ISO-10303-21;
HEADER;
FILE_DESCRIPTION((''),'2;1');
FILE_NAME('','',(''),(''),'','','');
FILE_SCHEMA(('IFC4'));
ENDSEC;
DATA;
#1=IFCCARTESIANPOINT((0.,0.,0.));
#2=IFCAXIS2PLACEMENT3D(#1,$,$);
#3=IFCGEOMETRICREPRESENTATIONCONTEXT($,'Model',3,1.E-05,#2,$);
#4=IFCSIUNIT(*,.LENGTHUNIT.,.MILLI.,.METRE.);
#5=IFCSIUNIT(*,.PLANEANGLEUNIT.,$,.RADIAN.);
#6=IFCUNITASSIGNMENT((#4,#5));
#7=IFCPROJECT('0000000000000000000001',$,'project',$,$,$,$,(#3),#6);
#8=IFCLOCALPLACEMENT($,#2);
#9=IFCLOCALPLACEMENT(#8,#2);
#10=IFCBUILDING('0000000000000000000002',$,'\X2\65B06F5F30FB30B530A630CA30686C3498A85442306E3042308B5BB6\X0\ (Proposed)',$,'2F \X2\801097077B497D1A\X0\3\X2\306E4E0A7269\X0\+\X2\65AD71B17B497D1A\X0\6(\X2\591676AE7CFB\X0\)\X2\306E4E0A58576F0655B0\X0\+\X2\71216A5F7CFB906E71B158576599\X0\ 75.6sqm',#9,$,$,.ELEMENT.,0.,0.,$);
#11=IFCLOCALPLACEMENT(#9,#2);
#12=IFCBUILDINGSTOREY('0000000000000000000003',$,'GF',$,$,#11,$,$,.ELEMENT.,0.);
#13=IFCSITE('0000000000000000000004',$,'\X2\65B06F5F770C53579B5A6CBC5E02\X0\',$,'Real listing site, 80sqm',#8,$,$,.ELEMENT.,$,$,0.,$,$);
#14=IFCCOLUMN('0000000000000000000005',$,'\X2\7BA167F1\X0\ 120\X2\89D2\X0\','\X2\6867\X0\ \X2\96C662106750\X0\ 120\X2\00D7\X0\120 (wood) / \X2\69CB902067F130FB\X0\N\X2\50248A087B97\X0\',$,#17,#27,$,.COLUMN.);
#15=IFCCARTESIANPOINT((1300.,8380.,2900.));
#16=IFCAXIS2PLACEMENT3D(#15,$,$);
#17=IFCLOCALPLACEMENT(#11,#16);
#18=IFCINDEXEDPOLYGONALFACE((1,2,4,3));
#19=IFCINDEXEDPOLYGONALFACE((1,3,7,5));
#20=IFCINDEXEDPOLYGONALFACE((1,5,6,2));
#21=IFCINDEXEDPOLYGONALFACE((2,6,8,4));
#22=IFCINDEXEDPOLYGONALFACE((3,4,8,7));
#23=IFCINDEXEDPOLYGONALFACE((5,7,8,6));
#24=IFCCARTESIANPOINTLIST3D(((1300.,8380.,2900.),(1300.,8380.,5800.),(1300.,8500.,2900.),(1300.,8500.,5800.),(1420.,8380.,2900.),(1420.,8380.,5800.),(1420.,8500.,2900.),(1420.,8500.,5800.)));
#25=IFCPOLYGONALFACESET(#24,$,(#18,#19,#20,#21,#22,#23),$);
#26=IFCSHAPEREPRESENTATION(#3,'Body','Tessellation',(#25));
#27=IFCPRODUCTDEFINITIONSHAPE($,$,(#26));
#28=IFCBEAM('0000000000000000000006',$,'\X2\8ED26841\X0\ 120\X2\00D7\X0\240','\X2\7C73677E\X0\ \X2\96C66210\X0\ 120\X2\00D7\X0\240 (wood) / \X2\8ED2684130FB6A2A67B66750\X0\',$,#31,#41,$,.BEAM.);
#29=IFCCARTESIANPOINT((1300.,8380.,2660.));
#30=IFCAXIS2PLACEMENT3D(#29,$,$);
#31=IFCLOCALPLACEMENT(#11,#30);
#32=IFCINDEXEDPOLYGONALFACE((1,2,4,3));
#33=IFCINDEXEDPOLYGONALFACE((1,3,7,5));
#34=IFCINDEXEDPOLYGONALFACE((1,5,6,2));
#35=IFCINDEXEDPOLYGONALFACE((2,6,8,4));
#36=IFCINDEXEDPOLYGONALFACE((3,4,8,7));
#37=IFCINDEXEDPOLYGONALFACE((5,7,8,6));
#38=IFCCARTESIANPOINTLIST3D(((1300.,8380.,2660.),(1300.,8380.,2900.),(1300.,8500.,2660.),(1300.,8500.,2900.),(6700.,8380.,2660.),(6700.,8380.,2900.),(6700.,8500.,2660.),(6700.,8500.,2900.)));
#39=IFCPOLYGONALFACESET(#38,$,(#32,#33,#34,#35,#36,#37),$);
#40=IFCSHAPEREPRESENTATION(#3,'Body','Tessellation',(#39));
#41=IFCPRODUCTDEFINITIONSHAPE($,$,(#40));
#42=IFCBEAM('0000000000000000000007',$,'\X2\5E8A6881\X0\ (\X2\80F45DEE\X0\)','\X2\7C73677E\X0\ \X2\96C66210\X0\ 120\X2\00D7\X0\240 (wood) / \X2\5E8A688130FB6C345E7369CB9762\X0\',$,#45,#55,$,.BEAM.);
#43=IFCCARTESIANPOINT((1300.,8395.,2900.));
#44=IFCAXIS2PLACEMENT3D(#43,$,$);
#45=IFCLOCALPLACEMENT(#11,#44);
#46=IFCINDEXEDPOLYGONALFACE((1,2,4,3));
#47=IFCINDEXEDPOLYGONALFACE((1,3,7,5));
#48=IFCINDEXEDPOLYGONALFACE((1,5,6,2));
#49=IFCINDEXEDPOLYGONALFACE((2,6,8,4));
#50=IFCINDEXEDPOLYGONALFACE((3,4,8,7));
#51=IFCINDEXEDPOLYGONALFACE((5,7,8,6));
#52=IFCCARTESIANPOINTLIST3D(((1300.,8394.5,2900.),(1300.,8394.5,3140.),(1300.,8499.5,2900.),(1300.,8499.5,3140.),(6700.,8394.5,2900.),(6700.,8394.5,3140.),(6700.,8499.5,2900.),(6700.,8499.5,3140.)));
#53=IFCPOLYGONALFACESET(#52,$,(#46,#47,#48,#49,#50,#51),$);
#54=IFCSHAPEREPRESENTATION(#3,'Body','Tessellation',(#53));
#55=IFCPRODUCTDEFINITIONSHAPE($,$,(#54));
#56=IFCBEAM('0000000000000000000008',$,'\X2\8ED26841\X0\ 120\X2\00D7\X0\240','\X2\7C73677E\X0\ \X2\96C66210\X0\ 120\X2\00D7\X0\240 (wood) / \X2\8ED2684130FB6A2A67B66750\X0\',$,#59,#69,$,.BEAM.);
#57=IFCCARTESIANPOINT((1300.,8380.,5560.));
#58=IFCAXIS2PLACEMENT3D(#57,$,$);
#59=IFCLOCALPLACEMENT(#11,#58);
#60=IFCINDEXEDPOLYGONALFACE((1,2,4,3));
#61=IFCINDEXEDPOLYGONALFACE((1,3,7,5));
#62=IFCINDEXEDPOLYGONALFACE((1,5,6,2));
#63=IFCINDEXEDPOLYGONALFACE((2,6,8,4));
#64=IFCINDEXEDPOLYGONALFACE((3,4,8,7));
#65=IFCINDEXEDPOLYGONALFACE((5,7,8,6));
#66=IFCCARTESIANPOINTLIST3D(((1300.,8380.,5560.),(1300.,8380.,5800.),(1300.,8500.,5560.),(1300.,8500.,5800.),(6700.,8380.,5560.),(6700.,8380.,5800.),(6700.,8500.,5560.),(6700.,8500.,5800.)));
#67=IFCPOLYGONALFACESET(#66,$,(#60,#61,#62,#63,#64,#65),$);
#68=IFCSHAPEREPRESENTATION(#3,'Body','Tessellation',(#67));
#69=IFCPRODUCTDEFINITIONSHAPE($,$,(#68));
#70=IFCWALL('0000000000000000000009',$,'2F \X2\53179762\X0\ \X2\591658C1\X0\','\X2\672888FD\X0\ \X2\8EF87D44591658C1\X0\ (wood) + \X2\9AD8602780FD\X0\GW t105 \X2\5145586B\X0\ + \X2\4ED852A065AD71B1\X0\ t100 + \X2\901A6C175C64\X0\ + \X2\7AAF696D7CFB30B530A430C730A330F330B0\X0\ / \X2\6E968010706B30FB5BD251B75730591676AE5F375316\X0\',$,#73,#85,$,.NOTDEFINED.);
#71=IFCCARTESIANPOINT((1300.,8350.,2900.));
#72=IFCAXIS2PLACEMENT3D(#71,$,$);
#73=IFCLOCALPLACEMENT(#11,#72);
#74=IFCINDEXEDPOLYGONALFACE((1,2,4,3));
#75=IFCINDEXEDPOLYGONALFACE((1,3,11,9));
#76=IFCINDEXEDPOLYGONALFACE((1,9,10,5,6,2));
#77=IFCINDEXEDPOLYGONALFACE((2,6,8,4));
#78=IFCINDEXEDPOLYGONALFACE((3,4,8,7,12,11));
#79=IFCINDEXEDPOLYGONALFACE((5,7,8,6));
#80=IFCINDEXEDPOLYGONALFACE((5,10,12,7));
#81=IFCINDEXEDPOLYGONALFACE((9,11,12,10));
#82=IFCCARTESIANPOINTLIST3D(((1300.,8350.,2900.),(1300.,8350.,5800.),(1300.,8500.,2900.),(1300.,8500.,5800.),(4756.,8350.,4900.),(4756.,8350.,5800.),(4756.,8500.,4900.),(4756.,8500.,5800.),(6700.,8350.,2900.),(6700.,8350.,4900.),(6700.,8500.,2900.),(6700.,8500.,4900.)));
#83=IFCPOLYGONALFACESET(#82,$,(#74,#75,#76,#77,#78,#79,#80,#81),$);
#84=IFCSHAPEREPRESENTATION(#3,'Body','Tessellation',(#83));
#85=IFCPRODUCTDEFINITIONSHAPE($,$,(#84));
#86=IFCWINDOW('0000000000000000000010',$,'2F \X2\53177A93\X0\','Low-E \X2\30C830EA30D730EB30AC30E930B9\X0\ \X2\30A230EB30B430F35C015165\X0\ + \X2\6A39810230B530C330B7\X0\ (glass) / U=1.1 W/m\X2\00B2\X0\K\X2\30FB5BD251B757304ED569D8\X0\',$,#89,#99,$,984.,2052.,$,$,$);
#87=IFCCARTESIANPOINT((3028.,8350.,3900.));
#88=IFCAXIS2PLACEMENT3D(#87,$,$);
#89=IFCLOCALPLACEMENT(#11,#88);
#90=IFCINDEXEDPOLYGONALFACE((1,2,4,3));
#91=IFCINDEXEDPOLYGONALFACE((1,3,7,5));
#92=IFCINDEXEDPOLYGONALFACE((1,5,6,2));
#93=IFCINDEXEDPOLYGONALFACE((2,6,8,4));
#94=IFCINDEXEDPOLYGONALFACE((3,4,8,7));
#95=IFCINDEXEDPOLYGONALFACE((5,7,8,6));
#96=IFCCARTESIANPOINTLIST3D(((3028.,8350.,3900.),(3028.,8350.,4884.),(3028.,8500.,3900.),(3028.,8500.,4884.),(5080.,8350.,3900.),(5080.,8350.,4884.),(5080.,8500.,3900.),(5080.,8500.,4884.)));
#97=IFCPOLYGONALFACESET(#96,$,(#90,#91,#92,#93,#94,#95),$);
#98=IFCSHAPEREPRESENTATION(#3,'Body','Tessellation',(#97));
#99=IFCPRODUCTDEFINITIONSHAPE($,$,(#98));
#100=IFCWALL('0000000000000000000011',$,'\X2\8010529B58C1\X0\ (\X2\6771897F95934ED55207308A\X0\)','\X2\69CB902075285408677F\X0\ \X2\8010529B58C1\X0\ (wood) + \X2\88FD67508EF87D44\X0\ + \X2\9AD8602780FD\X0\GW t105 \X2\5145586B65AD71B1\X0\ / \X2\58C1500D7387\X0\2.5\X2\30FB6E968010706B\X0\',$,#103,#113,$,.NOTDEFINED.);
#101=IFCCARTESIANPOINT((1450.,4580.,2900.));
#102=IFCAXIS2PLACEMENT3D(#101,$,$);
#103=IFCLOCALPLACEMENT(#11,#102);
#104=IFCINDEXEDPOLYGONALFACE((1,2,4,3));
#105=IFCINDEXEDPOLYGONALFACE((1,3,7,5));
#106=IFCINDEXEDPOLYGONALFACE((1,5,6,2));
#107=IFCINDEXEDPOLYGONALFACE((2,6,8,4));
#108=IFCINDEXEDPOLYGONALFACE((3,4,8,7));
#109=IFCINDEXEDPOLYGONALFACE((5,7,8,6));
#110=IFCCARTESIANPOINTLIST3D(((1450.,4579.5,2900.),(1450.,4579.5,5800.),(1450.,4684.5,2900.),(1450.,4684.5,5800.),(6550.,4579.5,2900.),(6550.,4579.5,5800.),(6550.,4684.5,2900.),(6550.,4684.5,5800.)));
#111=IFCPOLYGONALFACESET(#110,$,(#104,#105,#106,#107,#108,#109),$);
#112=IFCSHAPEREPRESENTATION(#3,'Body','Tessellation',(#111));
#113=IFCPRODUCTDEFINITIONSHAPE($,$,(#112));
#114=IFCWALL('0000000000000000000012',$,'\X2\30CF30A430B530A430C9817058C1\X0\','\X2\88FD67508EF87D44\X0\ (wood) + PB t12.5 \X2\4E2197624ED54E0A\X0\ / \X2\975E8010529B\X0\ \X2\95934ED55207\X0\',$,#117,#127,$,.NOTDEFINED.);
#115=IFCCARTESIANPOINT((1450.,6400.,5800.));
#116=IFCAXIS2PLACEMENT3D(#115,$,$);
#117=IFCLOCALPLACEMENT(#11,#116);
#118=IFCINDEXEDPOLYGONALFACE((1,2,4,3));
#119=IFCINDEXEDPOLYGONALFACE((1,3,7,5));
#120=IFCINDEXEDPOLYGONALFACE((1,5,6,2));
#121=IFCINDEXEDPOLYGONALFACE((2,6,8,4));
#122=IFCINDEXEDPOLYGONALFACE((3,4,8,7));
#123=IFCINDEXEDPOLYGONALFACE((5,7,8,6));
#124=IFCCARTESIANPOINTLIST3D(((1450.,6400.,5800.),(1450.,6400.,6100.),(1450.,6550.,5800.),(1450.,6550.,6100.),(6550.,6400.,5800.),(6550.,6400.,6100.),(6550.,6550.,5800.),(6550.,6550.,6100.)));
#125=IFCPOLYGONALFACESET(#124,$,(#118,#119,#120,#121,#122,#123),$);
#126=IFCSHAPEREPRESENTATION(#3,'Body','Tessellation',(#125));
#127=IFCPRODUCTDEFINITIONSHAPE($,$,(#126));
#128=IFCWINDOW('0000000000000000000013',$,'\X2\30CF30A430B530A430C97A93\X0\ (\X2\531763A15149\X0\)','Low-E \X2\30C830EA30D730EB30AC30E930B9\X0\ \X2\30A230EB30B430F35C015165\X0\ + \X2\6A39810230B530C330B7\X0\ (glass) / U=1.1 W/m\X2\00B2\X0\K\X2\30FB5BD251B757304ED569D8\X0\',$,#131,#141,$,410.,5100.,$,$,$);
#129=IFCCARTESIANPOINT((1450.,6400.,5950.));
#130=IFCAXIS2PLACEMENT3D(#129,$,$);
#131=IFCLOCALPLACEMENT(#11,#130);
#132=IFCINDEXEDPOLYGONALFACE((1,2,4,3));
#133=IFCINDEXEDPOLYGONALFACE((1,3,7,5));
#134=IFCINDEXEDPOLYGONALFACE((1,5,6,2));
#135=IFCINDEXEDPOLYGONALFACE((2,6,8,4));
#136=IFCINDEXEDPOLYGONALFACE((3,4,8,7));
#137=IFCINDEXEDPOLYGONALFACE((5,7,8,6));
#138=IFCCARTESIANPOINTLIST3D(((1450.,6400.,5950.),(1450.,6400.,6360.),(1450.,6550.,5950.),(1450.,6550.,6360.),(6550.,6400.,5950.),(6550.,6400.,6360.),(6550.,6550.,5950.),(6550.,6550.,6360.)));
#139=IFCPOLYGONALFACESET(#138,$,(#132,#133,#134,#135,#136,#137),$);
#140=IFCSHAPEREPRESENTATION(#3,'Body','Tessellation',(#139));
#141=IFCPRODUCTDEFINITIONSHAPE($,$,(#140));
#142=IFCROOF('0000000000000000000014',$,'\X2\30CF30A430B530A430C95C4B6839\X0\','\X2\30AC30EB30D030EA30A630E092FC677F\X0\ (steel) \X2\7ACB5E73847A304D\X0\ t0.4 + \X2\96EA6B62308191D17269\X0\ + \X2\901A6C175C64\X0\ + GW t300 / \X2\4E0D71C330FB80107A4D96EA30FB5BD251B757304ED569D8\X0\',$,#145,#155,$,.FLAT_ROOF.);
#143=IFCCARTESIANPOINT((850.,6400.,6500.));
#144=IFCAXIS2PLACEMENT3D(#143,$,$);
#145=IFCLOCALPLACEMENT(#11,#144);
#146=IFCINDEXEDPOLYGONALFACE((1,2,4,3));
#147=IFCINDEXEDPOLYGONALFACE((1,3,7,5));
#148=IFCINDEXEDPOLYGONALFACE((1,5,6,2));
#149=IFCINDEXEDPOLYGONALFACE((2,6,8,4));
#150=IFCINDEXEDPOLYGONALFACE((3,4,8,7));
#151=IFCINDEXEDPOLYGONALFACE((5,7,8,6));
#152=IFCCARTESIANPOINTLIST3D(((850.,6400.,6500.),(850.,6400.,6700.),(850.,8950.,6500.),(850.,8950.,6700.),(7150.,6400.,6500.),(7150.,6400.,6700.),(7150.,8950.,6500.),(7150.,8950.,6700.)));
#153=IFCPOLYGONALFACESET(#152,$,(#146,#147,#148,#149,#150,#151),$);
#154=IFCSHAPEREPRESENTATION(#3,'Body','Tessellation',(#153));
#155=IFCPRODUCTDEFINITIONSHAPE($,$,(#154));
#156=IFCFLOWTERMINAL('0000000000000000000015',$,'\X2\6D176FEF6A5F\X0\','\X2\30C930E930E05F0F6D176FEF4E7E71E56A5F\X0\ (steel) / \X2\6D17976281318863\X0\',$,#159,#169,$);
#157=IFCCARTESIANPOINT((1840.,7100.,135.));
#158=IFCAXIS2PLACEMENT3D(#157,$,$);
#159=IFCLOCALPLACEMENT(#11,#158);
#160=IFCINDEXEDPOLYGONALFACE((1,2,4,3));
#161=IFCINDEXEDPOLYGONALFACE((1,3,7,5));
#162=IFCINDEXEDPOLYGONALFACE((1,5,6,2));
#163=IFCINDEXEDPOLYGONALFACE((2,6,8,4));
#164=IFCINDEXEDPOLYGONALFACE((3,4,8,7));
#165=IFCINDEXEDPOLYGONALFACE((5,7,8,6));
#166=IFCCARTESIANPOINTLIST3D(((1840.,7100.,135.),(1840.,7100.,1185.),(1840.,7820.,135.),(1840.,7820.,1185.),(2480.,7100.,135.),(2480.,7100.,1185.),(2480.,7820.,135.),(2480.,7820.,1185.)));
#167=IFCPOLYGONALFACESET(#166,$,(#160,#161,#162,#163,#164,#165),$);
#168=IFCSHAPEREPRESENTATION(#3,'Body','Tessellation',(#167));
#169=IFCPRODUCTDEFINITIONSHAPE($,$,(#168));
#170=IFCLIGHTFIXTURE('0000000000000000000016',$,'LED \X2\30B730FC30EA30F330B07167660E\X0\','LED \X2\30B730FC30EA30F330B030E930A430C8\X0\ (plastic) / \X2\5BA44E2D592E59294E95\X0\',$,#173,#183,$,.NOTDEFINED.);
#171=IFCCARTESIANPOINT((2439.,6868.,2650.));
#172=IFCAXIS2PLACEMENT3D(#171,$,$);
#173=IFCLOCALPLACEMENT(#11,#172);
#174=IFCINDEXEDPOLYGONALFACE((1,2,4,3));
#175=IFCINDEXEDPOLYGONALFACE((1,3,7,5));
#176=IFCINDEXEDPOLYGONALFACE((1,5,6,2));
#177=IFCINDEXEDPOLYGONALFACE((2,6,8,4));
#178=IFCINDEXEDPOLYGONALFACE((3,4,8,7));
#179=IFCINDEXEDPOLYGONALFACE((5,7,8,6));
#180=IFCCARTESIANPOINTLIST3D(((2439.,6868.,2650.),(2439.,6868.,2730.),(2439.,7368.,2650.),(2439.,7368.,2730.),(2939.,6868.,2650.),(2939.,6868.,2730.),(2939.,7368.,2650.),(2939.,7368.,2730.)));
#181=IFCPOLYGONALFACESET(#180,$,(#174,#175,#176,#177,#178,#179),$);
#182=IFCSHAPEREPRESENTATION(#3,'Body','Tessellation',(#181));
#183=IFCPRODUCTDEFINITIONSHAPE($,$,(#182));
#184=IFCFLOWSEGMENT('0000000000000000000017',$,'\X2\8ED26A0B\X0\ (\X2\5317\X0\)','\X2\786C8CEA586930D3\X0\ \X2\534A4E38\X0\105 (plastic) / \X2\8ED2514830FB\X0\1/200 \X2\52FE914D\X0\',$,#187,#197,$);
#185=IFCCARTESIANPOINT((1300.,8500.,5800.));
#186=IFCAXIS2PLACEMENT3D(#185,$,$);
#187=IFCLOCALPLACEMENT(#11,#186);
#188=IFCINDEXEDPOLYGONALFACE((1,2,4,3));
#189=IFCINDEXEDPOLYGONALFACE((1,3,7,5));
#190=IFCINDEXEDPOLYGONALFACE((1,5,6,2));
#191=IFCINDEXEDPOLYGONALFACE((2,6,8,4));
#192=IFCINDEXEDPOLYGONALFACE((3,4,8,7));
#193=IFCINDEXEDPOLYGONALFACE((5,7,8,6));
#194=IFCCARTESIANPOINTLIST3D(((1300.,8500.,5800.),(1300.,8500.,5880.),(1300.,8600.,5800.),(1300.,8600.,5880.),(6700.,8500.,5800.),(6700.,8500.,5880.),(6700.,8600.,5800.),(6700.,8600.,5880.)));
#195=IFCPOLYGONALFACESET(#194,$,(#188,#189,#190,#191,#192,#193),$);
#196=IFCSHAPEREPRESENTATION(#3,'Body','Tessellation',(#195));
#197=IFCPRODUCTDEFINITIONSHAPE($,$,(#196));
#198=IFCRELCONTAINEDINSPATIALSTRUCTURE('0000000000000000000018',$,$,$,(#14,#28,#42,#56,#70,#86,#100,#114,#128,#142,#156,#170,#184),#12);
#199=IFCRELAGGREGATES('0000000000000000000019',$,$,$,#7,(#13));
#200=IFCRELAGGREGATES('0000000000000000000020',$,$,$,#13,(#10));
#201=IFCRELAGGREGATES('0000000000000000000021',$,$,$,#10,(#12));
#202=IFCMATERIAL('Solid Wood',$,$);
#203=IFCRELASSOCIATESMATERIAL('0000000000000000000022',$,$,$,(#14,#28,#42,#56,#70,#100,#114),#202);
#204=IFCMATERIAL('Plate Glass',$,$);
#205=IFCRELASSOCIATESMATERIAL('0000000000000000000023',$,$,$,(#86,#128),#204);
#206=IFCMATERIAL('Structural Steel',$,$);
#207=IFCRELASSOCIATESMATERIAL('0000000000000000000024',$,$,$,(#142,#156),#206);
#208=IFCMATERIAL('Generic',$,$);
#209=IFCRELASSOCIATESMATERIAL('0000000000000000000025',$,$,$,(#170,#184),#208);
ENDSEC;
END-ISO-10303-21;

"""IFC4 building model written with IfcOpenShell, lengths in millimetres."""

from ifc_helpers import new_model, si_unit, frame, frame_2d, origin, place, context, project, spatial, rectangle, extrude, material, element, fill, save


model = new_model("IFC4")

# Units and contexts
model_context = context("Model", 3, precision=1e-05, world=origin())
ifc_project = project(units=[si_unit("LENGTHUNIT", "METRE", prefix="MILLI"), si_unit("PLANEANGLEUNIT", "RADIAN")], contexts=[model_context])

# Site, building, storey
site_placement = place(None, origin())
site = spatial("IfcSite", under=ifc_project, at=site_placement, Name="新潟県南魚沼市", ObjectType="Real listing site, 80sqm", CompositionType="ELEMENT", RefElevation=0.0)
building_placement = place(site_placement, origin())
building = spatial("IfcBuilding", under=site, at=building_placement, Name="新潟・サウナと水風呂のある家 (Proposed)", ObjectType="2F 耐震等級3の上物+断熱等級6(外皮系)の上塗漆喰+無機系遮熱塗料 75.6sqm", CompositionType="ELEMENT", ElevationOfRefHeight=0.0, ElevationOfTerrain=0.0)
storey_placement = place(building_placement, origin())
storey = spatial("IfcBuildingStorey", under=building, at=storey_placement, Name="GF", CompositionType="ELEMENT", Elevation=0.0)

# Column
ifc_material_1 = material(Name="Solid Wood")
column_1_placement = place(storey_placement, frame((1300.0, 8380.0, 2900.0)))
element("IfcColumn", 1, at=column_1_placement, inside=storey, material=ifc_material_1, Name="管柱 120角", Description="桧 集成材 120×120 (wood) / 構造柱・N値計算", PredefinedType="COLUMN", context=model_context, shape_type="SweptSolid", body=[
    extrude(rectangle(XDim=120.0, YDim=120.0, at=frame_2d((60.0, 60.0))), frame((1300.0, 8380.0, 2900.0)), (0.0, 0.0, 1.0), 2900.0),
])

# Beams
beam_1_placement = place(storey_placement, frame((1300.0, 8380.0, 2660.0)))
element("IfcBeam", 2, at=beam_1_placement, inside=storey, material=ifc_material_1, Name="軒桁 120×240", Description="米松 集成 120×240 (wood) / 軒桁・横架材", PredefinedType="BEAM", context=model_context, shape_type="SweptSolid", body=[
    extrude(rectangle(XDim=5400.0, YDim=120.0, at=frame_2d((2700.0, 60.0))), frame((1300.0, 8380.0, 2660.0)), (0.0, 0.0, 1.0), 240.0),
])
beam_2_placement = place(storey_placement, frame((1300.0, 8395.0, 2900.0)))
element("IfcBeam", 3, at=beam_2_placement, inside=storey, material=ifc_material_1, Name="床梁 (胴差)", Description="米松 集成 120×240 (wood) / 床梁・水平構面", PredefinedType="BEAM", context=model_context, shape_type="SweptSolid", body=[
    extrude(rectangle(XDim=5400.0, YDim=105.0, at=frame_2d((2700.0, 52.0))), frame((1300.0, 8395.0, 2900.0)), (0.0, 0.0, 1.0), 240.0),
])
beam_3_placement = place(storey_placement, frame((1300.0, 8380.0, 5560.0)))
element("IfcBeam", 4, at=beam_3_placement, inside=storey, material=ifc_material_1, Name="軒桁 120×240", Description="米松 集成 120×240 (wood) / 軒桁・横架材", PredefinedType="BEAM", context=model_context, shape_type="SweptSolid", body=[
    extrude(rectangle(XDim=5400.0, YDim=120.0, at=frame_2d((2700.0, 60.0))), frame((1300.0, 8380.0, 5560.0)), (0.0, 0.0, 1.0), 240.0),
])

# Wall, opening, window
wall_1_placement = place(storey_placement, frame((1300.0, 8350.0, 2900.0)))
wall_1 = element("IfcWall", 5, at=wall_1_placement, inside=storey, material=ifc_material_1, Name="2F 北面 外壁", Description="木製 軸組外壁 (wood) + 高性能GW t105 充填 + 付加断熱 t100 + 通気層 + 窯業系サイディング / 準耐火・寒冷地外皮強化", PredefinedType="NOTDEFINED", context=model_context, shape_type="SweptSolid", body=[
    extrude(rectangle(XDim=5400.0, YDim=150.0, at=frame_2d((2700.0, 75.0))), frame((1300.0, 8350.0, 2900.0)), (0.0, 0.0, 1.0), 2900.0),
])
opening_1_placement = place(storey_placement, frame((3028.0, 8350.0, 3900.0)))
opening_1 = element("IfcOpeningElement", 6, at=opening_1_placement, cuts=wall_1, PredefinedType="NOTDEFINED", context=model_context, shape_type="SweptSolid", body=[
    extrude(rectangle(XDim=2052.0, YDim=150.0, at=frame_2d((1026.0, 75.0))), frame((3028.0, 8350.0, 3900.0)), (0.0, 0.0, 1.0), 984.0),
])
ifc_material_2 = material(Name="Plate Glass")
window_1_placement = place(storey_placement, frame((3028.0, 8350.0, 3900.0)))
window_1 = element("IfcWindow", 7, at=window_1_placement, inside=storey, material=ifc_material_2, Name="2F 北窓", Description="Low-E トリプルガラス アルゴン封入 + 樹脂サッシ (glass) / U=1.1 W/m²K・寒冷地仕様", OverallHeight=984.0, OverallWidth=2052.0, context=model_context, shape_type="SweptSolid", body=[
    extrude(rectangle(XDim=2052.0, YDim=150.0, at=frame_2d((1026.0, 75.0))), frame((3028.0, 8350.0, 3900.0)), (0.0, 0.0, 1.0), 984.0),
])
fill(opening_1, window_1)

# Wall
wall_2_placement = place(storey_placement, frame((1450.0, 4580.0, 2900.0)))
element("IfcWall", 8, at=wall_2_placement, inside=storey, material=ifc_material_1, Name="耐力壁 (東西間仕切り)", Description="構造用合板 耐力壁 (wood) + 製材軸組 + 高性能GW t105 充填断熱 / 壁倍率2.5・準耐火", PredefinedType="NOTDEFINED", context=model_context, shape_type="SweptSolid", body=[
    extrude(rectangle(XDim=5100.0, YDim=105.0, at=frame_2d((2550.0, 52.0))), frame((1450.0, 4580.0, 2900.0)), (0.0, 0.0, 1.0), 2900.0),
])

# Wall, opening, window
wall_3_placement = place(storey_placement, frame((1450.0, 6400.0, 5800.0)))
wall_3 = element("IfcWall", 9, at=wall_3_placement, inside=storey, material=ifc_material_1, Name="ハイサイド腰壁", Description="製材軸組 (wood) + PB t12.5 両面仕上 / 非耐力 間仕切", PredefinedType="NOTDEFINED", context=model_context, shape_type="SweptSolid", body=[
    extrude(rectangle(XDim=5100.0, YDim=150.0, at=frame_2d((2550.0, 75.0))), frame((1450.0, 6400.0, 5800.0)), (0.0, 0.0, 1.0), 700.0),
])
opening_2_placement = place(storey_placement, frame((1450.0, 6400.0, 5950.0)))
opening_2 = element("IfcOpeningElement", 10, at=opening_2_placement, cuts=wall_3, PredefinedType="NOTDEFINED", context=model_context, shape_type="SweptSolid", body=[
    extrude(rectangle(XDim=5100.0, YDim=150.0, at=frame_2d((2550.0, 75.0))), frame((1450.0, 6400.0, 5950.0)), (0.0, 0.0, 1.0), 410.0),
])
window_2_placement = place(storey_placement, frame((1450.0, 6400.0, 5950.0)))
window_2 = element("IfcWindow", 11, at=window_2_placement, inside=storey, material=ifc_material_2, Name="ハイサイド窓 (北採光)", Description="Low-E トリプルガラス アルゴン封入 + 樹脂サッシ (glass) / U=1.1 W/m²K・寒冷地仕様", OverallHeight=410.0, OverallWidth=5100.0, context=model_context, shape_type="SweptSolid", body=[
    extrude(rectangle(XDim=5100.0, YDim=150.0, at=frame_2d((2550.0, 75.0))), frame((1450.0, 6400.0, 5950.0)), (0.0, 0.0, 1.0), 410.0),
])
fill(opening_2, window_2)

# Roof
ifc_material_3 = material(Name="Structural Steel")
roof_placement = place(storey_placement, frame((850.0, 6400.0, 6500.0)))
element("IfcRoof", 12, at=roof_placement, inside=storey, material=ifc_material_3, Name="ハイサイド屋根", Description="ガルバリウム鋼板 (steel) 立平葺き t0.4 + 雪止め金物 + 通気層 + GW t300 / 不燃・耐積雪・寒冷地仕様", PredefinedType="FLAT_ROOF", context=model_context, shape_type="SweptSolid", body=[
    extrude(rectangle(XDim=6300.0, YDim=2550.0, at=frame_2d((3150.0, 1275.0))), frame((850.0, 6400.0, 6500.0)), (0.0, 0.0, 1.0), 200.0),
])

# Flow terminal
flow_terminal_placement = place(storey_placement, frame((1840.0, 7100.0, 135.0)))
element("IfcFlowTerminal", 13, at=flow_terminal_placement, inside=storey, material=ifc_material_3, Name="洗濯機", Description="ドラム式洗濯乾燥機 (steel) / 洗面脱衣", context=model_context, shape_type="SweptSolid", body=[
    extrude(rectangle(XDim=640.0, YDim=720.0, at=frame_2d((320.0, 360.0))), frame((1840.0, 7100.0, 135.0)), (0.0, 0.0, 1.0), 1050.0),
])

# Light fixture
ifc_material_4 = material(Name="Generic")
light_fixture_placement = place(storey_placement, frame((2439.0, 6868.0, 2650.0)))
element("IfcLightFixture", 14, at=light_fixture_placement, inside=storey, material=ifc_material_4, Name="LED シーリング照明", Description="LED シーリングライト (plastic) / 室中央天井", PredefinedType="NOTDEFINED", context=model_context, shape_type="SweptSolid", body=[
    extrude(rectangle(XDim=500.0, YDim=500.0, at=frame_2d((250.0, 250.0))), frame((2439.0, 6868.0, 2650.0)), (0.0, 0.0, 1.0), 80.0),
])

# Flow segment
flow_segment_placement = place(storey_placement, frame((1300.0, 8500.0, 5800.0)))
element("IfcFlowSegment", 15, at=flow_segment_placement, inside=storey, material=ifc_material_4, Name="軒樋 (北)", Description="硬質塩ビ 半丸105 (plastic) / 軒先・1/200 勾配", context=model_context, shape_type="SweptSolid", body=[
    extrude(rectangle(XDim=5400.0, YDim=100.0, at=frame_2d((2700.0, 50.0))), frame((1300.0, 8500.0, 5800.0)), (0.0, 0.0, 1.0), 80.0),
])

save(model, "model.ifc")
